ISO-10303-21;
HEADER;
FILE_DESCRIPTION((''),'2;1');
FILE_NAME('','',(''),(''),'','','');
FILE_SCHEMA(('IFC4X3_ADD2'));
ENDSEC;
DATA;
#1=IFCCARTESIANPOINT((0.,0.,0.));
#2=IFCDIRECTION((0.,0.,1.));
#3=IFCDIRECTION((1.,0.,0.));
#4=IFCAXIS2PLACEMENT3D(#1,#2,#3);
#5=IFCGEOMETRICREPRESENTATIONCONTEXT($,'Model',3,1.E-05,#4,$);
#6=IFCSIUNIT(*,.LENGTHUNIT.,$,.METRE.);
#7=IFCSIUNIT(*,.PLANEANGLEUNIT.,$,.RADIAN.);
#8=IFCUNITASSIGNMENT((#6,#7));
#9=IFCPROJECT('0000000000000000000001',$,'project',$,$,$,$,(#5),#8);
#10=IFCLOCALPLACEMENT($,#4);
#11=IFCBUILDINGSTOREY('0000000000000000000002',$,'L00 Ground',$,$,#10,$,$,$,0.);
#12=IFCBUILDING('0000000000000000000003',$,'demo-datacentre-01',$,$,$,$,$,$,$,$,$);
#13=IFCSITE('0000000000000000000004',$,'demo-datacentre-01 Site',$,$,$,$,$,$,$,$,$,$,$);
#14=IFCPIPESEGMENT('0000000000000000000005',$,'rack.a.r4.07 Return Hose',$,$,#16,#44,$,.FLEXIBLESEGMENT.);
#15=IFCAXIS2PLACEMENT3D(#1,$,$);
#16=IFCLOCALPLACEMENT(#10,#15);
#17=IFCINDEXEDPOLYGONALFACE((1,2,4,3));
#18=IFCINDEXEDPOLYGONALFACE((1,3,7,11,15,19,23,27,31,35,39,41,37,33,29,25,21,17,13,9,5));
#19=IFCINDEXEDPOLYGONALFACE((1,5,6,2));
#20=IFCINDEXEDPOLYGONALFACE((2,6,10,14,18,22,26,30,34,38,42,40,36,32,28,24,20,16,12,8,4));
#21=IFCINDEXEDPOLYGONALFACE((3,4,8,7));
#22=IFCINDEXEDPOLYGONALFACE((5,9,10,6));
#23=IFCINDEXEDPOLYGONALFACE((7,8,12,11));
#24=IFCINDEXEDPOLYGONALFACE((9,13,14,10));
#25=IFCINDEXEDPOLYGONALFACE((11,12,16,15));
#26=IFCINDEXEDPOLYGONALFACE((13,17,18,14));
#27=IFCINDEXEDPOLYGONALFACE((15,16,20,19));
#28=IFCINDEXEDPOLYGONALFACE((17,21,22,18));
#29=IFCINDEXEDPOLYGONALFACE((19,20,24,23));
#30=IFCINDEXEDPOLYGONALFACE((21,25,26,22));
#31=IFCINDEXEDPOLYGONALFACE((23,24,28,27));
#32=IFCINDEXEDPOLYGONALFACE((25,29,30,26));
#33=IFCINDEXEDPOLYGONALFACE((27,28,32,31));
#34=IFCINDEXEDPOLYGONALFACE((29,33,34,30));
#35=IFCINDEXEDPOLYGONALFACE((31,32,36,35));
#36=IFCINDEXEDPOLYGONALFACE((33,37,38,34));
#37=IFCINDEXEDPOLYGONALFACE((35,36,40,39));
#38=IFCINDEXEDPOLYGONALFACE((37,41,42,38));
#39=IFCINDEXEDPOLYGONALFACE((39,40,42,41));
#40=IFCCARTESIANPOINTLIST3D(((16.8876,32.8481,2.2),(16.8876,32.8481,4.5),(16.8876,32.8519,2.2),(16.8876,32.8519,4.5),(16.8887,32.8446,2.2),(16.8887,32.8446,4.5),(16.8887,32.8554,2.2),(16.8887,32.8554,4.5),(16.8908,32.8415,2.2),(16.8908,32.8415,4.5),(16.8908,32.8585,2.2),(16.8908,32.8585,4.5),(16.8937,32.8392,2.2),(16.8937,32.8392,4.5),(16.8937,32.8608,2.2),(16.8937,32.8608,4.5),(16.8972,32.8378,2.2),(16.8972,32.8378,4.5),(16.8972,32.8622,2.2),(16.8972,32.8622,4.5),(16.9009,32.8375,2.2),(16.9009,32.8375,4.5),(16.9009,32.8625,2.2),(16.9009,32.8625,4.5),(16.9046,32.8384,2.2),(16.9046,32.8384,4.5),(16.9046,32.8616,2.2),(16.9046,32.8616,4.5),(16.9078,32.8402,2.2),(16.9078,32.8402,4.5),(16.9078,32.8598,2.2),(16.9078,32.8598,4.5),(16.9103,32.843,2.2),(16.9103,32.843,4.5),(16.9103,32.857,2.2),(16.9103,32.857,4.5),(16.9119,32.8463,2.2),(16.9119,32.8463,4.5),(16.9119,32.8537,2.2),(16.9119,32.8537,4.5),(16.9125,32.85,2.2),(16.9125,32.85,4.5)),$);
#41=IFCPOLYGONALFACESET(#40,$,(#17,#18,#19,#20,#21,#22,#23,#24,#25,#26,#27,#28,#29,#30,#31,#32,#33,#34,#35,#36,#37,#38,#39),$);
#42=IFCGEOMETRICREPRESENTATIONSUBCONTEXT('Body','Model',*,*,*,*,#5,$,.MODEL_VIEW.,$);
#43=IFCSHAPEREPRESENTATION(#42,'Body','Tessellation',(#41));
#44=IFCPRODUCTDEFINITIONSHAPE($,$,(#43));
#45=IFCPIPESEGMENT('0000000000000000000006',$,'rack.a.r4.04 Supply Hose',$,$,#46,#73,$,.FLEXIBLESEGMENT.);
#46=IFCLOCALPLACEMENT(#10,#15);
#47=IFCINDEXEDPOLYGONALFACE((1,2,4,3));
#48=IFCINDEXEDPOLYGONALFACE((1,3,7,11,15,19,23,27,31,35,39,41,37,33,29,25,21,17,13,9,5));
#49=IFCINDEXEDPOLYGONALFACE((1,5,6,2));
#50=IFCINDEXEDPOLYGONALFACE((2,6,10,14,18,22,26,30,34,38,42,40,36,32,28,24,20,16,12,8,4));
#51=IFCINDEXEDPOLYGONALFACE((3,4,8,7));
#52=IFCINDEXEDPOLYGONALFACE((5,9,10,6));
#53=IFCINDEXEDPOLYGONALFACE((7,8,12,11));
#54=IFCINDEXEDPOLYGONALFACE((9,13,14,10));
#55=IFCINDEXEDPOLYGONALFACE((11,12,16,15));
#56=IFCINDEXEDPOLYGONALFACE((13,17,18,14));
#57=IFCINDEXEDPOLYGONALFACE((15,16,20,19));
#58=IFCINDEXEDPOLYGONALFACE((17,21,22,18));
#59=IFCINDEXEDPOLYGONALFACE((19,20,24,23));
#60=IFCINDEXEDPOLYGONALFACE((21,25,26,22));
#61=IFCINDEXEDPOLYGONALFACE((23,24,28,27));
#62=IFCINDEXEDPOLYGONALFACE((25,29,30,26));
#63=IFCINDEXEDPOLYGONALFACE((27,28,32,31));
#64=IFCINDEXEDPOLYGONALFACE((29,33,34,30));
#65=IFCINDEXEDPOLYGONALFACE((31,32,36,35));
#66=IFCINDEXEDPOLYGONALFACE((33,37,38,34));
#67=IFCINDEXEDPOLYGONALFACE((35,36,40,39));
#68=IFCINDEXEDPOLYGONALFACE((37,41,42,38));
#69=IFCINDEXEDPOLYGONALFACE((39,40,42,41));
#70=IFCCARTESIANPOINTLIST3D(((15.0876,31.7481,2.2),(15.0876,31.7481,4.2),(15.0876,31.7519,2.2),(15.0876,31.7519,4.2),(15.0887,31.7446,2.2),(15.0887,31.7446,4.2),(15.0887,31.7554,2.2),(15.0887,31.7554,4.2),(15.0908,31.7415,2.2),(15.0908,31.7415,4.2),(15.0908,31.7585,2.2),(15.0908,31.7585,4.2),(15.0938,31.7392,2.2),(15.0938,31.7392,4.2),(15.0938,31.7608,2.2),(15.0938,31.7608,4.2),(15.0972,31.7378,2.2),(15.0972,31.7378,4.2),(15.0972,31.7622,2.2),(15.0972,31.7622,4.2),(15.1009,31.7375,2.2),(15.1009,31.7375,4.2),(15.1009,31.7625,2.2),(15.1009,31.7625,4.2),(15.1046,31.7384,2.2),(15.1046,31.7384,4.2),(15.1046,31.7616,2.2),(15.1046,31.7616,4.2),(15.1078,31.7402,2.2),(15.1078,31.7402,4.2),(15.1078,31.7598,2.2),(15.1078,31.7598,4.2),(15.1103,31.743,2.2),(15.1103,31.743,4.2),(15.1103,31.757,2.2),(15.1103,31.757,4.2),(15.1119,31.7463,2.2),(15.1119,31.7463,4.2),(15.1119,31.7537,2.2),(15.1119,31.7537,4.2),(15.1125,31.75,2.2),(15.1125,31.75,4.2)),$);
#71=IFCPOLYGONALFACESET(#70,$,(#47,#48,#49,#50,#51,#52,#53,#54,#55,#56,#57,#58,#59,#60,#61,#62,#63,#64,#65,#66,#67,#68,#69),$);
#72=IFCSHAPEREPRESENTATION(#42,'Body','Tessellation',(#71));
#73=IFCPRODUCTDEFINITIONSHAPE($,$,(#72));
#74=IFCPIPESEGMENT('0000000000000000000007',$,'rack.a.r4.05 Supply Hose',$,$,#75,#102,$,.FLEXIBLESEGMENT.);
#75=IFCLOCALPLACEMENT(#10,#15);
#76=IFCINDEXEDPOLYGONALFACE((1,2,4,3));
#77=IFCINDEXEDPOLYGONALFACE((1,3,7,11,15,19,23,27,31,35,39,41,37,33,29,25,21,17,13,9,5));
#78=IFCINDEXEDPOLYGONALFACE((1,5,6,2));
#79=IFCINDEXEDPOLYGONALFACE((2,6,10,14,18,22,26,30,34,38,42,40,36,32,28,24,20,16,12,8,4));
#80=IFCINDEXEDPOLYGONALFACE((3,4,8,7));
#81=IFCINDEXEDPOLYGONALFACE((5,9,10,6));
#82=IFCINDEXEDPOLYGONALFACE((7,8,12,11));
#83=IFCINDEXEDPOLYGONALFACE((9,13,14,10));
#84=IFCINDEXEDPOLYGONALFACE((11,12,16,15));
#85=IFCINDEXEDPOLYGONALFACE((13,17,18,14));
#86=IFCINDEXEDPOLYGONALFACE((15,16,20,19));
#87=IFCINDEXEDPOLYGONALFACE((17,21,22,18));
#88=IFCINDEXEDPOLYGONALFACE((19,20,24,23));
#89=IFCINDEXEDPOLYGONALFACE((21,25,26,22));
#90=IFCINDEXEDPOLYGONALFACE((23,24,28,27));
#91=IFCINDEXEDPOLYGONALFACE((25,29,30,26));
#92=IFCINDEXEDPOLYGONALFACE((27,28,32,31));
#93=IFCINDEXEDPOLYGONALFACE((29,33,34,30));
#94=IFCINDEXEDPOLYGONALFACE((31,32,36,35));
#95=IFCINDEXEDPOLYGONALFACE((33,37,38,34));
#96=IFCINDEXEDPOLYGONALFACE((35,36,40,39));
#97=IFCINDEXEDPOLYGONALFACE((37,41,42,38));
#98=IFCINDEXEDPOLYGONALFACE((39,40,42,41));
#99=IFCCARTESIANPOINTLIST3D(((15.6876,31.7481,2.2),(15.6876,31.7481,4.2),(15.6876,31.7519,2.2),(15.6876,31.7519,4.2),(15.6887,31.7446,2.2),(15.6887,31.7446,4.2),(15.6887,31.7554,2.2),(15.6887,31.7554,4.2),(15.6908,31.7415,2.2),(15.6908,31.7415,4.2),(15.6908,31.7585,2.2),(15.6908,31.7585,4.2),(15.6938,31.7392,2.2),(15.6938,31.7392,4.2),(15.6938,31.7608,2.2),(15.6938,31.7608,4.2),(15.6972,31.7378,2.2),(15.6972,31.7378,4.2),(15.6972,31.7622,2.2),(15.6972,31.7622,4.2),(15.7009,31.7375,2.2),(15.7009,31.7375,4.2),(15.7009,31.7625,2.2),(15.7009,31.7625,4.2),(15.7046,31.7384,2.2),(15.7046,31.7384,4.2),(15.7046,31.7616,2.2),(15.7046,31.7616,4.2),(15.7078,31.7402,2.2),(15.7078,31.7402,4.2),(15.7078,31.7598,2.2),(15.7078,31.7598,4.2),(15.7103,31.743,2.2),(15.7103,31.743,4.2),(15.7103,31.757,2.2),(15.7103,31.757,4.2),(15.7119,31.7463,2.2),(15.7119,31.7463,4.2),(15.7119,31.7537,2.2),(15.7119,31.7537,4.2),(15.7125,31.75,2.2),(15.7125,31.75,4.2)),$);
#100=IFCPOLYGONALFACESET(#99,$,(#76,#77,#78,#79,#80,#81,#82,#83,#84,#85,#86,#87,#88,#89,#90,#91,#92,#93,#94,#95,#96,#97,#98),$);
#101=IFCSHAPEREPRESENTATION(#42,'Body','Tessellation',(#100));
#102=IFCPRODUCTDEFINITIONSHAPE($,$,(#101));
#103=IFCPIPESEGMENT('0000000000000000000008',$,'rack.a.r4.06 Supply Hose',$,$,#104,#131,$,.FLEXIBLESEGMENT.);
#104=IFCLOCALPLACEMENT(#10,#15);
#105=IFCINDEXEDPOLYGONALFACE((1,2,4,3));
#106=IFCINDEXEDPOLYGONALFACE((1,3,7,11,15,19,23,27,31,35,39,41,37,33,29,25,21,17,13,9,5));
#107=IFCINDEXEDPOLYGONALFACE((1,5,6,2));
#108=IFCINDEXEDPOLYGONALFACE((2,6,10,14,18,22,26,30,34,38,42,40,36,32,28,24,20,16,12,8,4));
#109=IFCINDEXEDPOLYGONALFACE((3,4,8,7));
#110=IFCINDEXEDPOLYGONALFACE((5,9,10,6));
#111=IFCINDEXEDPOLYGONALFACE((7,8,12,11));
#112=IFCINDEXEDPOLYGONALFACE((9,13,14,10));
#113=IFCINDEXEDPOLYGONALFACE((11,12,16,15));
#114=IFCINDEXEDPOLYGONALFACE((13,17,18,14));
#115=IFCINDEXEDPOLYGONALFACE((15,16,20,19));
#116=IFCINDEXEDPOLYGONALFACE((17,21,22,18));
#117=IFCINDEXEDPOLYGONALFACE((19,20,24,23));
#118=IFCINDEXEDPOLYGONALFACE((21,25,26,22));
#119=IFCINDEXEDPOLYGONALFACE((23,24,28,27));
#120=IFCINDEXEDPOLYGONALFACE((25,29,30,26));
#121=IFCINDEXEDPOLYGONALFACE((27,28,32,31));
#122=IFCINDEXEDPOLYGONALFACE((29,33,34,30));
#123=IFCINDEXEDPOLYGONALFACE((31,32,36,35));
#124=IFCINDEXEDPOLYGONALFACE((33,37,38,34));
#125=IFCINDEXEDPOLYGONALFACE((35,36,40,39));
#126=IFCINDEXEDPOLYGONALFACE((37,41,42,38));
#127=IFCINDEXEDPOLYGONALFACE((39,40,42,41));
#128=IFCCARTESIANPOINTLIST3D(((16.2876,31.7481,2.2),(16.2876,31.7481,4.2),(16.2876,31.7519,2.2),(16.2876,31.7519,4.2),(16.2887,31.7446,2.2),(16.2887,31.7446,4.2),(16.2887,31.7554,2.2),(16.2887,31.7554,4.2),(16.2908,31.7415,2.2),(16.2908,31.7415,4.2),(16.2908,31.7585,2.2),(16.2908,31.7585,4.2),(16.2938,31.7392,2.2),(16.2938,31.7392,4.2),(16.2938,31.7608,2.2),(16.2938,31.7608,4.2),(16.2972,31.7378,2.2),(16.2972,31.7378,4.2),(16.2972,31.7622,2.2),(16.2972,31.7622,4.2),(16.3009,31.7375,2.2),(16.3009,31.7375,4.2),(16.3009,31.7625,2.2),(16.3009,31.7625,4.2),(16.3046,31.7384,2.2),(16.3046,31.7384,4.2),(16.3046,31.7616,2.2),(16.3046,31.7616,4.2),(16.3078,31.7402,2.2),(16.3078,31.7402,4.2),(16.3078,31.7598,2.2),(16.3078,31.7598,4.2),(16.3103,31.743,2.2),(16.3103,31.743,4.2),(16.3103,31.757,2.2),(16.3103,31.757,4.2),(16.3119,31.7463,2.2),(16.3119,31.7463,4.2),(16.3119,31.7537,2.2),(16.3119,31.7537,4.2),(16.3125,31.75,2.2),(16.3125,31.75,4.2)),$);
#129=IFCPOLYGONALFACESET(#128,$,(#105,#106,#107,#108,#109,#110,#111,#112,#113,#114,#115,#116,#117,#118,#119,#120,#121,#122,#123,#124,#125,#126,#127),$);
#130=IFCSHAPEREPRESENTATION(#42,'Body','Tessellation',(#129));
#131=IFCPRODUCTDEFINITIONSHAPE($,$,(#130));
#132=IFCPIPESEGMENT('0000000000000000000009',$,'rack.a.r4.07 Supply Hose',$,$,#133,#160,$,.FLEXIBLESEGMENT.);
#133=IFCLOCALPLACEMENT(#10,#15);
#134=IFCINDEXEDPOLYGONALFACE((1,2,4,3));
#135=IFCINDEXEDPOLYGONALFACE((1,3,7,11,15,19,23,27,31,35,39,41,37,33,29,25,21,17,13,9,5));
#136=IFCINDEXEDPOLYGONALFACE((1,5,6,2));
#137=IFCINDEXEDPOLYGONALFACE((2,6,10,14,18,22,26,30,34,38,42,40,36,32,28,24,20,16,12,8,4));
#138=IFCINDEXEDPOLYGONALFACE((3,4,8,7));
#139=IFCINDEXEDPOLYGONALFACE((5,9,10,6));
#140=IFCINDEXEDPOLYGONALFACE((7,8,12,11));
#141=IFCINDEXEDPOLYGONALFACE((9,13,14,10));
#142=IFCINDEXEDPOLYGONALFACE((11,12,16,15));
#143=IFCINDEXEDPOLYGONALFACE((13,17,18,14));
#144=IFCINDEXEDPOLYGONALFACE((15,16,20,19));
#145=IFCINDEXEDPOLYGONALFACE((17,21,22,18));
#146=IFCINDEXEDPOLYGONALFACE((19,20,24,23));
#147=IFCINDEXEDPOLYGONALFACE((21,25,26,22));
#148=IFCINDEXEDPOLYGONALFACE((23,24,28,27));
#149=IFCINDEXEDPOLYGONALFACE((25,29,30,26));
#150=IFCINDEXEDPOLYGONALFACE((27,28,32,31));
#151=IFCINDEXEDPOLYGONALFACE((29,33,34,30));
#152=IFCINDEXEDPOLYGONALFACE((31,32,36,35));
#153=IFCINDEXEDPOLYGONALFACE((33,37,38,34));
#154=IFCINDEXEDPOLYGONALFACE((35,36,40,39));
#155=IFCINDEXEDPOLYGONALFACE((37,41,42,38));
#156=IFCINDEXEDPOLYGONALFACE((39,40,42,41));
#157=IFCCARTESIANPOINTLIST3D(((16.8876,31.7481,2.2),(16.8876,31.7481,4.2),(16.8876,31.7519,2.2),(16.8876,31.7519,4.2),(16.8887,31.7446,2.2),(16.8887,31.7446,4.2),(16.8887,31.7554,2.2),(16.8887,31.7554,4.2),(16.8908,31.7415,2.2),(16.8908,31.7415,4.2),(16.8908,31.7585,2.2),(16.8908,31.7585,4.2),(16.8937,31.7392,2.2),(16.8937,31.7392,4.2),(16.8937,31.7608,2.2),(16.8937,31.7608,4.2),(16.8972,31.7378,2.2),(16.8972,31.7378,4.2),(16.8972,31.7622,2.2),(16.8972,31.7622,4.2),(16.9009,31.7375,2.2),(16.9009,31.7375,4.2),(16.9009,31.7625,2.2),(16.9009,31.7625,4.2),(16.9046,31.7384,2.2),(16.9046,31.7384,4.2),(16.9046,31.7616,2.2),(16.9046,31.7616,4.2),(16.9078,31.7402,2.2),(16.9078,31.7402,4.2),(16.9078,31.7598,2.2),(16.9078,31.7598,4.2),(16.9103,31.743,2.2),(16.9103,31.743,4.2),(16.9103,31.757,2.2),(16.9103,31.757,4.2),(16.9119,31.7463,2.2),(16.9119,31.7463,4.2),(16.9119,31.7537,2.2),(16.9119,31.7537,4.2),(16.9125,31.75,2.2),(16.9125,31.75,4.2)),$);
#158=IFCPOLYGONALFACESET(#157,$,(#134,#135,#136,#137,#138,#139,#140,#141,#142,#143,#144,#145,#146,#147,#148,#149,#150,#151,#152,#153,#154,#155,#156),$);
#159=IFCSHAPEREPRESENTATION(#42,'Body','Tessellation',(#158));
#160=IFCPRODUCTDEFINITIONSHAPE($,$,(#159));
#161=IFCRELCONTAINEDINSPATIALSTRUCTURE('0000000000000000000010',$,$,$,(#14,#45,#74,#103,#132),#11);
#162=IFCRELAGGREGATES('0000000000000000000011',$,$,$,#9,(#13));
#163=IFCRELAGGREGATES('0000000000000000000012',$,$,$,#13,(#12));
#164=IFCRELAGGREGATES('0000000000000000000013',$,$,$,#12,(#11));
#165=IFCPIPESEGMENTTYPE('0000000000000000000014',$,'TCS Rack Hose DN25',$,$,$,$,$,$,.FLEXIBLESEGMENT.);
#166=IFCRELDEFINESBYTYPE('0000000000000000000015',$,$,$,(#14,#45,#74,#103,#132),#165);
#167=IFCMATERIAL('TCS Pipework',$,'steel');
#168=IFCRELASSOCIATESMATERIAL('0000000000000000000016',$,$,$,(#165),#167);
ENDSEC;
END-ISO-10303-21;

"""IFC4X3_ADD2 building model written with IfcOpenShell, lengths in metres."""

from ifc_helpers import new_model, si_unit, frame, origin_with_axes, place, context, subcontext, project, spatial, circle, extrude, material, type_object, element, save


model = new_model("IFC4X3_ADD2")

# Units and contexts
model_context = context("Model", 3, precision=1e-05, world=origin_with_axes())
body_context = subcontext(model_context, "Body", "Model", "MODEL_VIEW")
ifc_project = project(units=[si_unit("LENGTHUNIT", "METRE"), si_unit("PLANEANGLEUNIT", "RADIAN")], contexts=[model_context])

# Site, building, storey
site = spatial("IfcSite", under=ifc_project, Name="demo-datacentre-01 Site")
building = spatial("IfcBuilding", under=site, Name="demo-datacentre-01")
storey_placement = place(None, origin_with_axes())
storey = spatial("IfcBuildingStorey", under=building, at=storey_placement, Name="L00 Ground", Elevation=0.0)

# Shared definitions
ifc_material = material(Name="TCS Pipework", Category="steel")

# Pipe segments
pipe_segment_type_1 = type_object("IfcPipeSegmentType", Name="TCS Rack Hose DN25", PredefinedType="FLEXIBLESEGMENT", material=ifc_material)
for number, where, z_axis, x_axis, name in (
    (1, (16.9, 32.85, 4.5), (0.0, 0.0, -1.0), (1.0, 0.0, 0.0), "rack.a.r4.07 Return Hose"),
):
    element("IfcPipeSegment", number, at=place(storey_placement, frame(where, z_axis=z_axis, x_axis=x_axis)), inside=storey, type_object=pipe_segment_type_1, Name=name, PredefinedType="FLEXIBLESEGMENT", context=body_context, shape_type="SweptSolid", body=[
        extrude(circle(Radius=0.0125), origin_with_axes(), (0.0, 0.0, 1.0), 2.3),
    ])
for number, where, z_axis, x_axis, name in (
    (2, (15.1, 31.75, 4.2), (0.0, 0.0, -1.0), (1.0, 0.0, 0.0), "rack.a.r4.04 Supply Hose"),
    (3, (15.7, 31.75, 4.2), (0.0, 0.0, -1.0), (1.0, 0.0, 0.0), "rack.a.r4.05 Supply Hose"),
    (4, (16.3, 31.75, 4.2), (0.0, 0.0, -1.0), (1.0, 0.0, 0.0), "rack.a.r4.06 Supply Hose"),
    (5, (16.9, 31.75, 4.2), (0.0, 0.0, -1.0), (1.0, 0.0, 0.0), "rack.a.r4.07 Supply Hose"),
):
    element("IfcPipeSegment", number, at=place(storey_placement, frame(where, z_axis=z_axis, x_axis=x_axis)), inside=storey, type_object=pipe_segment_type_1, Name=name, PredefinedType="FLEXIBLESEGMENT", context=body_context, shape_type="SweptSolid", body=[
        extrude(circle(Radius=0.0125), origin_with_axes(), (0.0, 0.0, 1.0), 2.0),
    ])

save(model, "model.ifc")
